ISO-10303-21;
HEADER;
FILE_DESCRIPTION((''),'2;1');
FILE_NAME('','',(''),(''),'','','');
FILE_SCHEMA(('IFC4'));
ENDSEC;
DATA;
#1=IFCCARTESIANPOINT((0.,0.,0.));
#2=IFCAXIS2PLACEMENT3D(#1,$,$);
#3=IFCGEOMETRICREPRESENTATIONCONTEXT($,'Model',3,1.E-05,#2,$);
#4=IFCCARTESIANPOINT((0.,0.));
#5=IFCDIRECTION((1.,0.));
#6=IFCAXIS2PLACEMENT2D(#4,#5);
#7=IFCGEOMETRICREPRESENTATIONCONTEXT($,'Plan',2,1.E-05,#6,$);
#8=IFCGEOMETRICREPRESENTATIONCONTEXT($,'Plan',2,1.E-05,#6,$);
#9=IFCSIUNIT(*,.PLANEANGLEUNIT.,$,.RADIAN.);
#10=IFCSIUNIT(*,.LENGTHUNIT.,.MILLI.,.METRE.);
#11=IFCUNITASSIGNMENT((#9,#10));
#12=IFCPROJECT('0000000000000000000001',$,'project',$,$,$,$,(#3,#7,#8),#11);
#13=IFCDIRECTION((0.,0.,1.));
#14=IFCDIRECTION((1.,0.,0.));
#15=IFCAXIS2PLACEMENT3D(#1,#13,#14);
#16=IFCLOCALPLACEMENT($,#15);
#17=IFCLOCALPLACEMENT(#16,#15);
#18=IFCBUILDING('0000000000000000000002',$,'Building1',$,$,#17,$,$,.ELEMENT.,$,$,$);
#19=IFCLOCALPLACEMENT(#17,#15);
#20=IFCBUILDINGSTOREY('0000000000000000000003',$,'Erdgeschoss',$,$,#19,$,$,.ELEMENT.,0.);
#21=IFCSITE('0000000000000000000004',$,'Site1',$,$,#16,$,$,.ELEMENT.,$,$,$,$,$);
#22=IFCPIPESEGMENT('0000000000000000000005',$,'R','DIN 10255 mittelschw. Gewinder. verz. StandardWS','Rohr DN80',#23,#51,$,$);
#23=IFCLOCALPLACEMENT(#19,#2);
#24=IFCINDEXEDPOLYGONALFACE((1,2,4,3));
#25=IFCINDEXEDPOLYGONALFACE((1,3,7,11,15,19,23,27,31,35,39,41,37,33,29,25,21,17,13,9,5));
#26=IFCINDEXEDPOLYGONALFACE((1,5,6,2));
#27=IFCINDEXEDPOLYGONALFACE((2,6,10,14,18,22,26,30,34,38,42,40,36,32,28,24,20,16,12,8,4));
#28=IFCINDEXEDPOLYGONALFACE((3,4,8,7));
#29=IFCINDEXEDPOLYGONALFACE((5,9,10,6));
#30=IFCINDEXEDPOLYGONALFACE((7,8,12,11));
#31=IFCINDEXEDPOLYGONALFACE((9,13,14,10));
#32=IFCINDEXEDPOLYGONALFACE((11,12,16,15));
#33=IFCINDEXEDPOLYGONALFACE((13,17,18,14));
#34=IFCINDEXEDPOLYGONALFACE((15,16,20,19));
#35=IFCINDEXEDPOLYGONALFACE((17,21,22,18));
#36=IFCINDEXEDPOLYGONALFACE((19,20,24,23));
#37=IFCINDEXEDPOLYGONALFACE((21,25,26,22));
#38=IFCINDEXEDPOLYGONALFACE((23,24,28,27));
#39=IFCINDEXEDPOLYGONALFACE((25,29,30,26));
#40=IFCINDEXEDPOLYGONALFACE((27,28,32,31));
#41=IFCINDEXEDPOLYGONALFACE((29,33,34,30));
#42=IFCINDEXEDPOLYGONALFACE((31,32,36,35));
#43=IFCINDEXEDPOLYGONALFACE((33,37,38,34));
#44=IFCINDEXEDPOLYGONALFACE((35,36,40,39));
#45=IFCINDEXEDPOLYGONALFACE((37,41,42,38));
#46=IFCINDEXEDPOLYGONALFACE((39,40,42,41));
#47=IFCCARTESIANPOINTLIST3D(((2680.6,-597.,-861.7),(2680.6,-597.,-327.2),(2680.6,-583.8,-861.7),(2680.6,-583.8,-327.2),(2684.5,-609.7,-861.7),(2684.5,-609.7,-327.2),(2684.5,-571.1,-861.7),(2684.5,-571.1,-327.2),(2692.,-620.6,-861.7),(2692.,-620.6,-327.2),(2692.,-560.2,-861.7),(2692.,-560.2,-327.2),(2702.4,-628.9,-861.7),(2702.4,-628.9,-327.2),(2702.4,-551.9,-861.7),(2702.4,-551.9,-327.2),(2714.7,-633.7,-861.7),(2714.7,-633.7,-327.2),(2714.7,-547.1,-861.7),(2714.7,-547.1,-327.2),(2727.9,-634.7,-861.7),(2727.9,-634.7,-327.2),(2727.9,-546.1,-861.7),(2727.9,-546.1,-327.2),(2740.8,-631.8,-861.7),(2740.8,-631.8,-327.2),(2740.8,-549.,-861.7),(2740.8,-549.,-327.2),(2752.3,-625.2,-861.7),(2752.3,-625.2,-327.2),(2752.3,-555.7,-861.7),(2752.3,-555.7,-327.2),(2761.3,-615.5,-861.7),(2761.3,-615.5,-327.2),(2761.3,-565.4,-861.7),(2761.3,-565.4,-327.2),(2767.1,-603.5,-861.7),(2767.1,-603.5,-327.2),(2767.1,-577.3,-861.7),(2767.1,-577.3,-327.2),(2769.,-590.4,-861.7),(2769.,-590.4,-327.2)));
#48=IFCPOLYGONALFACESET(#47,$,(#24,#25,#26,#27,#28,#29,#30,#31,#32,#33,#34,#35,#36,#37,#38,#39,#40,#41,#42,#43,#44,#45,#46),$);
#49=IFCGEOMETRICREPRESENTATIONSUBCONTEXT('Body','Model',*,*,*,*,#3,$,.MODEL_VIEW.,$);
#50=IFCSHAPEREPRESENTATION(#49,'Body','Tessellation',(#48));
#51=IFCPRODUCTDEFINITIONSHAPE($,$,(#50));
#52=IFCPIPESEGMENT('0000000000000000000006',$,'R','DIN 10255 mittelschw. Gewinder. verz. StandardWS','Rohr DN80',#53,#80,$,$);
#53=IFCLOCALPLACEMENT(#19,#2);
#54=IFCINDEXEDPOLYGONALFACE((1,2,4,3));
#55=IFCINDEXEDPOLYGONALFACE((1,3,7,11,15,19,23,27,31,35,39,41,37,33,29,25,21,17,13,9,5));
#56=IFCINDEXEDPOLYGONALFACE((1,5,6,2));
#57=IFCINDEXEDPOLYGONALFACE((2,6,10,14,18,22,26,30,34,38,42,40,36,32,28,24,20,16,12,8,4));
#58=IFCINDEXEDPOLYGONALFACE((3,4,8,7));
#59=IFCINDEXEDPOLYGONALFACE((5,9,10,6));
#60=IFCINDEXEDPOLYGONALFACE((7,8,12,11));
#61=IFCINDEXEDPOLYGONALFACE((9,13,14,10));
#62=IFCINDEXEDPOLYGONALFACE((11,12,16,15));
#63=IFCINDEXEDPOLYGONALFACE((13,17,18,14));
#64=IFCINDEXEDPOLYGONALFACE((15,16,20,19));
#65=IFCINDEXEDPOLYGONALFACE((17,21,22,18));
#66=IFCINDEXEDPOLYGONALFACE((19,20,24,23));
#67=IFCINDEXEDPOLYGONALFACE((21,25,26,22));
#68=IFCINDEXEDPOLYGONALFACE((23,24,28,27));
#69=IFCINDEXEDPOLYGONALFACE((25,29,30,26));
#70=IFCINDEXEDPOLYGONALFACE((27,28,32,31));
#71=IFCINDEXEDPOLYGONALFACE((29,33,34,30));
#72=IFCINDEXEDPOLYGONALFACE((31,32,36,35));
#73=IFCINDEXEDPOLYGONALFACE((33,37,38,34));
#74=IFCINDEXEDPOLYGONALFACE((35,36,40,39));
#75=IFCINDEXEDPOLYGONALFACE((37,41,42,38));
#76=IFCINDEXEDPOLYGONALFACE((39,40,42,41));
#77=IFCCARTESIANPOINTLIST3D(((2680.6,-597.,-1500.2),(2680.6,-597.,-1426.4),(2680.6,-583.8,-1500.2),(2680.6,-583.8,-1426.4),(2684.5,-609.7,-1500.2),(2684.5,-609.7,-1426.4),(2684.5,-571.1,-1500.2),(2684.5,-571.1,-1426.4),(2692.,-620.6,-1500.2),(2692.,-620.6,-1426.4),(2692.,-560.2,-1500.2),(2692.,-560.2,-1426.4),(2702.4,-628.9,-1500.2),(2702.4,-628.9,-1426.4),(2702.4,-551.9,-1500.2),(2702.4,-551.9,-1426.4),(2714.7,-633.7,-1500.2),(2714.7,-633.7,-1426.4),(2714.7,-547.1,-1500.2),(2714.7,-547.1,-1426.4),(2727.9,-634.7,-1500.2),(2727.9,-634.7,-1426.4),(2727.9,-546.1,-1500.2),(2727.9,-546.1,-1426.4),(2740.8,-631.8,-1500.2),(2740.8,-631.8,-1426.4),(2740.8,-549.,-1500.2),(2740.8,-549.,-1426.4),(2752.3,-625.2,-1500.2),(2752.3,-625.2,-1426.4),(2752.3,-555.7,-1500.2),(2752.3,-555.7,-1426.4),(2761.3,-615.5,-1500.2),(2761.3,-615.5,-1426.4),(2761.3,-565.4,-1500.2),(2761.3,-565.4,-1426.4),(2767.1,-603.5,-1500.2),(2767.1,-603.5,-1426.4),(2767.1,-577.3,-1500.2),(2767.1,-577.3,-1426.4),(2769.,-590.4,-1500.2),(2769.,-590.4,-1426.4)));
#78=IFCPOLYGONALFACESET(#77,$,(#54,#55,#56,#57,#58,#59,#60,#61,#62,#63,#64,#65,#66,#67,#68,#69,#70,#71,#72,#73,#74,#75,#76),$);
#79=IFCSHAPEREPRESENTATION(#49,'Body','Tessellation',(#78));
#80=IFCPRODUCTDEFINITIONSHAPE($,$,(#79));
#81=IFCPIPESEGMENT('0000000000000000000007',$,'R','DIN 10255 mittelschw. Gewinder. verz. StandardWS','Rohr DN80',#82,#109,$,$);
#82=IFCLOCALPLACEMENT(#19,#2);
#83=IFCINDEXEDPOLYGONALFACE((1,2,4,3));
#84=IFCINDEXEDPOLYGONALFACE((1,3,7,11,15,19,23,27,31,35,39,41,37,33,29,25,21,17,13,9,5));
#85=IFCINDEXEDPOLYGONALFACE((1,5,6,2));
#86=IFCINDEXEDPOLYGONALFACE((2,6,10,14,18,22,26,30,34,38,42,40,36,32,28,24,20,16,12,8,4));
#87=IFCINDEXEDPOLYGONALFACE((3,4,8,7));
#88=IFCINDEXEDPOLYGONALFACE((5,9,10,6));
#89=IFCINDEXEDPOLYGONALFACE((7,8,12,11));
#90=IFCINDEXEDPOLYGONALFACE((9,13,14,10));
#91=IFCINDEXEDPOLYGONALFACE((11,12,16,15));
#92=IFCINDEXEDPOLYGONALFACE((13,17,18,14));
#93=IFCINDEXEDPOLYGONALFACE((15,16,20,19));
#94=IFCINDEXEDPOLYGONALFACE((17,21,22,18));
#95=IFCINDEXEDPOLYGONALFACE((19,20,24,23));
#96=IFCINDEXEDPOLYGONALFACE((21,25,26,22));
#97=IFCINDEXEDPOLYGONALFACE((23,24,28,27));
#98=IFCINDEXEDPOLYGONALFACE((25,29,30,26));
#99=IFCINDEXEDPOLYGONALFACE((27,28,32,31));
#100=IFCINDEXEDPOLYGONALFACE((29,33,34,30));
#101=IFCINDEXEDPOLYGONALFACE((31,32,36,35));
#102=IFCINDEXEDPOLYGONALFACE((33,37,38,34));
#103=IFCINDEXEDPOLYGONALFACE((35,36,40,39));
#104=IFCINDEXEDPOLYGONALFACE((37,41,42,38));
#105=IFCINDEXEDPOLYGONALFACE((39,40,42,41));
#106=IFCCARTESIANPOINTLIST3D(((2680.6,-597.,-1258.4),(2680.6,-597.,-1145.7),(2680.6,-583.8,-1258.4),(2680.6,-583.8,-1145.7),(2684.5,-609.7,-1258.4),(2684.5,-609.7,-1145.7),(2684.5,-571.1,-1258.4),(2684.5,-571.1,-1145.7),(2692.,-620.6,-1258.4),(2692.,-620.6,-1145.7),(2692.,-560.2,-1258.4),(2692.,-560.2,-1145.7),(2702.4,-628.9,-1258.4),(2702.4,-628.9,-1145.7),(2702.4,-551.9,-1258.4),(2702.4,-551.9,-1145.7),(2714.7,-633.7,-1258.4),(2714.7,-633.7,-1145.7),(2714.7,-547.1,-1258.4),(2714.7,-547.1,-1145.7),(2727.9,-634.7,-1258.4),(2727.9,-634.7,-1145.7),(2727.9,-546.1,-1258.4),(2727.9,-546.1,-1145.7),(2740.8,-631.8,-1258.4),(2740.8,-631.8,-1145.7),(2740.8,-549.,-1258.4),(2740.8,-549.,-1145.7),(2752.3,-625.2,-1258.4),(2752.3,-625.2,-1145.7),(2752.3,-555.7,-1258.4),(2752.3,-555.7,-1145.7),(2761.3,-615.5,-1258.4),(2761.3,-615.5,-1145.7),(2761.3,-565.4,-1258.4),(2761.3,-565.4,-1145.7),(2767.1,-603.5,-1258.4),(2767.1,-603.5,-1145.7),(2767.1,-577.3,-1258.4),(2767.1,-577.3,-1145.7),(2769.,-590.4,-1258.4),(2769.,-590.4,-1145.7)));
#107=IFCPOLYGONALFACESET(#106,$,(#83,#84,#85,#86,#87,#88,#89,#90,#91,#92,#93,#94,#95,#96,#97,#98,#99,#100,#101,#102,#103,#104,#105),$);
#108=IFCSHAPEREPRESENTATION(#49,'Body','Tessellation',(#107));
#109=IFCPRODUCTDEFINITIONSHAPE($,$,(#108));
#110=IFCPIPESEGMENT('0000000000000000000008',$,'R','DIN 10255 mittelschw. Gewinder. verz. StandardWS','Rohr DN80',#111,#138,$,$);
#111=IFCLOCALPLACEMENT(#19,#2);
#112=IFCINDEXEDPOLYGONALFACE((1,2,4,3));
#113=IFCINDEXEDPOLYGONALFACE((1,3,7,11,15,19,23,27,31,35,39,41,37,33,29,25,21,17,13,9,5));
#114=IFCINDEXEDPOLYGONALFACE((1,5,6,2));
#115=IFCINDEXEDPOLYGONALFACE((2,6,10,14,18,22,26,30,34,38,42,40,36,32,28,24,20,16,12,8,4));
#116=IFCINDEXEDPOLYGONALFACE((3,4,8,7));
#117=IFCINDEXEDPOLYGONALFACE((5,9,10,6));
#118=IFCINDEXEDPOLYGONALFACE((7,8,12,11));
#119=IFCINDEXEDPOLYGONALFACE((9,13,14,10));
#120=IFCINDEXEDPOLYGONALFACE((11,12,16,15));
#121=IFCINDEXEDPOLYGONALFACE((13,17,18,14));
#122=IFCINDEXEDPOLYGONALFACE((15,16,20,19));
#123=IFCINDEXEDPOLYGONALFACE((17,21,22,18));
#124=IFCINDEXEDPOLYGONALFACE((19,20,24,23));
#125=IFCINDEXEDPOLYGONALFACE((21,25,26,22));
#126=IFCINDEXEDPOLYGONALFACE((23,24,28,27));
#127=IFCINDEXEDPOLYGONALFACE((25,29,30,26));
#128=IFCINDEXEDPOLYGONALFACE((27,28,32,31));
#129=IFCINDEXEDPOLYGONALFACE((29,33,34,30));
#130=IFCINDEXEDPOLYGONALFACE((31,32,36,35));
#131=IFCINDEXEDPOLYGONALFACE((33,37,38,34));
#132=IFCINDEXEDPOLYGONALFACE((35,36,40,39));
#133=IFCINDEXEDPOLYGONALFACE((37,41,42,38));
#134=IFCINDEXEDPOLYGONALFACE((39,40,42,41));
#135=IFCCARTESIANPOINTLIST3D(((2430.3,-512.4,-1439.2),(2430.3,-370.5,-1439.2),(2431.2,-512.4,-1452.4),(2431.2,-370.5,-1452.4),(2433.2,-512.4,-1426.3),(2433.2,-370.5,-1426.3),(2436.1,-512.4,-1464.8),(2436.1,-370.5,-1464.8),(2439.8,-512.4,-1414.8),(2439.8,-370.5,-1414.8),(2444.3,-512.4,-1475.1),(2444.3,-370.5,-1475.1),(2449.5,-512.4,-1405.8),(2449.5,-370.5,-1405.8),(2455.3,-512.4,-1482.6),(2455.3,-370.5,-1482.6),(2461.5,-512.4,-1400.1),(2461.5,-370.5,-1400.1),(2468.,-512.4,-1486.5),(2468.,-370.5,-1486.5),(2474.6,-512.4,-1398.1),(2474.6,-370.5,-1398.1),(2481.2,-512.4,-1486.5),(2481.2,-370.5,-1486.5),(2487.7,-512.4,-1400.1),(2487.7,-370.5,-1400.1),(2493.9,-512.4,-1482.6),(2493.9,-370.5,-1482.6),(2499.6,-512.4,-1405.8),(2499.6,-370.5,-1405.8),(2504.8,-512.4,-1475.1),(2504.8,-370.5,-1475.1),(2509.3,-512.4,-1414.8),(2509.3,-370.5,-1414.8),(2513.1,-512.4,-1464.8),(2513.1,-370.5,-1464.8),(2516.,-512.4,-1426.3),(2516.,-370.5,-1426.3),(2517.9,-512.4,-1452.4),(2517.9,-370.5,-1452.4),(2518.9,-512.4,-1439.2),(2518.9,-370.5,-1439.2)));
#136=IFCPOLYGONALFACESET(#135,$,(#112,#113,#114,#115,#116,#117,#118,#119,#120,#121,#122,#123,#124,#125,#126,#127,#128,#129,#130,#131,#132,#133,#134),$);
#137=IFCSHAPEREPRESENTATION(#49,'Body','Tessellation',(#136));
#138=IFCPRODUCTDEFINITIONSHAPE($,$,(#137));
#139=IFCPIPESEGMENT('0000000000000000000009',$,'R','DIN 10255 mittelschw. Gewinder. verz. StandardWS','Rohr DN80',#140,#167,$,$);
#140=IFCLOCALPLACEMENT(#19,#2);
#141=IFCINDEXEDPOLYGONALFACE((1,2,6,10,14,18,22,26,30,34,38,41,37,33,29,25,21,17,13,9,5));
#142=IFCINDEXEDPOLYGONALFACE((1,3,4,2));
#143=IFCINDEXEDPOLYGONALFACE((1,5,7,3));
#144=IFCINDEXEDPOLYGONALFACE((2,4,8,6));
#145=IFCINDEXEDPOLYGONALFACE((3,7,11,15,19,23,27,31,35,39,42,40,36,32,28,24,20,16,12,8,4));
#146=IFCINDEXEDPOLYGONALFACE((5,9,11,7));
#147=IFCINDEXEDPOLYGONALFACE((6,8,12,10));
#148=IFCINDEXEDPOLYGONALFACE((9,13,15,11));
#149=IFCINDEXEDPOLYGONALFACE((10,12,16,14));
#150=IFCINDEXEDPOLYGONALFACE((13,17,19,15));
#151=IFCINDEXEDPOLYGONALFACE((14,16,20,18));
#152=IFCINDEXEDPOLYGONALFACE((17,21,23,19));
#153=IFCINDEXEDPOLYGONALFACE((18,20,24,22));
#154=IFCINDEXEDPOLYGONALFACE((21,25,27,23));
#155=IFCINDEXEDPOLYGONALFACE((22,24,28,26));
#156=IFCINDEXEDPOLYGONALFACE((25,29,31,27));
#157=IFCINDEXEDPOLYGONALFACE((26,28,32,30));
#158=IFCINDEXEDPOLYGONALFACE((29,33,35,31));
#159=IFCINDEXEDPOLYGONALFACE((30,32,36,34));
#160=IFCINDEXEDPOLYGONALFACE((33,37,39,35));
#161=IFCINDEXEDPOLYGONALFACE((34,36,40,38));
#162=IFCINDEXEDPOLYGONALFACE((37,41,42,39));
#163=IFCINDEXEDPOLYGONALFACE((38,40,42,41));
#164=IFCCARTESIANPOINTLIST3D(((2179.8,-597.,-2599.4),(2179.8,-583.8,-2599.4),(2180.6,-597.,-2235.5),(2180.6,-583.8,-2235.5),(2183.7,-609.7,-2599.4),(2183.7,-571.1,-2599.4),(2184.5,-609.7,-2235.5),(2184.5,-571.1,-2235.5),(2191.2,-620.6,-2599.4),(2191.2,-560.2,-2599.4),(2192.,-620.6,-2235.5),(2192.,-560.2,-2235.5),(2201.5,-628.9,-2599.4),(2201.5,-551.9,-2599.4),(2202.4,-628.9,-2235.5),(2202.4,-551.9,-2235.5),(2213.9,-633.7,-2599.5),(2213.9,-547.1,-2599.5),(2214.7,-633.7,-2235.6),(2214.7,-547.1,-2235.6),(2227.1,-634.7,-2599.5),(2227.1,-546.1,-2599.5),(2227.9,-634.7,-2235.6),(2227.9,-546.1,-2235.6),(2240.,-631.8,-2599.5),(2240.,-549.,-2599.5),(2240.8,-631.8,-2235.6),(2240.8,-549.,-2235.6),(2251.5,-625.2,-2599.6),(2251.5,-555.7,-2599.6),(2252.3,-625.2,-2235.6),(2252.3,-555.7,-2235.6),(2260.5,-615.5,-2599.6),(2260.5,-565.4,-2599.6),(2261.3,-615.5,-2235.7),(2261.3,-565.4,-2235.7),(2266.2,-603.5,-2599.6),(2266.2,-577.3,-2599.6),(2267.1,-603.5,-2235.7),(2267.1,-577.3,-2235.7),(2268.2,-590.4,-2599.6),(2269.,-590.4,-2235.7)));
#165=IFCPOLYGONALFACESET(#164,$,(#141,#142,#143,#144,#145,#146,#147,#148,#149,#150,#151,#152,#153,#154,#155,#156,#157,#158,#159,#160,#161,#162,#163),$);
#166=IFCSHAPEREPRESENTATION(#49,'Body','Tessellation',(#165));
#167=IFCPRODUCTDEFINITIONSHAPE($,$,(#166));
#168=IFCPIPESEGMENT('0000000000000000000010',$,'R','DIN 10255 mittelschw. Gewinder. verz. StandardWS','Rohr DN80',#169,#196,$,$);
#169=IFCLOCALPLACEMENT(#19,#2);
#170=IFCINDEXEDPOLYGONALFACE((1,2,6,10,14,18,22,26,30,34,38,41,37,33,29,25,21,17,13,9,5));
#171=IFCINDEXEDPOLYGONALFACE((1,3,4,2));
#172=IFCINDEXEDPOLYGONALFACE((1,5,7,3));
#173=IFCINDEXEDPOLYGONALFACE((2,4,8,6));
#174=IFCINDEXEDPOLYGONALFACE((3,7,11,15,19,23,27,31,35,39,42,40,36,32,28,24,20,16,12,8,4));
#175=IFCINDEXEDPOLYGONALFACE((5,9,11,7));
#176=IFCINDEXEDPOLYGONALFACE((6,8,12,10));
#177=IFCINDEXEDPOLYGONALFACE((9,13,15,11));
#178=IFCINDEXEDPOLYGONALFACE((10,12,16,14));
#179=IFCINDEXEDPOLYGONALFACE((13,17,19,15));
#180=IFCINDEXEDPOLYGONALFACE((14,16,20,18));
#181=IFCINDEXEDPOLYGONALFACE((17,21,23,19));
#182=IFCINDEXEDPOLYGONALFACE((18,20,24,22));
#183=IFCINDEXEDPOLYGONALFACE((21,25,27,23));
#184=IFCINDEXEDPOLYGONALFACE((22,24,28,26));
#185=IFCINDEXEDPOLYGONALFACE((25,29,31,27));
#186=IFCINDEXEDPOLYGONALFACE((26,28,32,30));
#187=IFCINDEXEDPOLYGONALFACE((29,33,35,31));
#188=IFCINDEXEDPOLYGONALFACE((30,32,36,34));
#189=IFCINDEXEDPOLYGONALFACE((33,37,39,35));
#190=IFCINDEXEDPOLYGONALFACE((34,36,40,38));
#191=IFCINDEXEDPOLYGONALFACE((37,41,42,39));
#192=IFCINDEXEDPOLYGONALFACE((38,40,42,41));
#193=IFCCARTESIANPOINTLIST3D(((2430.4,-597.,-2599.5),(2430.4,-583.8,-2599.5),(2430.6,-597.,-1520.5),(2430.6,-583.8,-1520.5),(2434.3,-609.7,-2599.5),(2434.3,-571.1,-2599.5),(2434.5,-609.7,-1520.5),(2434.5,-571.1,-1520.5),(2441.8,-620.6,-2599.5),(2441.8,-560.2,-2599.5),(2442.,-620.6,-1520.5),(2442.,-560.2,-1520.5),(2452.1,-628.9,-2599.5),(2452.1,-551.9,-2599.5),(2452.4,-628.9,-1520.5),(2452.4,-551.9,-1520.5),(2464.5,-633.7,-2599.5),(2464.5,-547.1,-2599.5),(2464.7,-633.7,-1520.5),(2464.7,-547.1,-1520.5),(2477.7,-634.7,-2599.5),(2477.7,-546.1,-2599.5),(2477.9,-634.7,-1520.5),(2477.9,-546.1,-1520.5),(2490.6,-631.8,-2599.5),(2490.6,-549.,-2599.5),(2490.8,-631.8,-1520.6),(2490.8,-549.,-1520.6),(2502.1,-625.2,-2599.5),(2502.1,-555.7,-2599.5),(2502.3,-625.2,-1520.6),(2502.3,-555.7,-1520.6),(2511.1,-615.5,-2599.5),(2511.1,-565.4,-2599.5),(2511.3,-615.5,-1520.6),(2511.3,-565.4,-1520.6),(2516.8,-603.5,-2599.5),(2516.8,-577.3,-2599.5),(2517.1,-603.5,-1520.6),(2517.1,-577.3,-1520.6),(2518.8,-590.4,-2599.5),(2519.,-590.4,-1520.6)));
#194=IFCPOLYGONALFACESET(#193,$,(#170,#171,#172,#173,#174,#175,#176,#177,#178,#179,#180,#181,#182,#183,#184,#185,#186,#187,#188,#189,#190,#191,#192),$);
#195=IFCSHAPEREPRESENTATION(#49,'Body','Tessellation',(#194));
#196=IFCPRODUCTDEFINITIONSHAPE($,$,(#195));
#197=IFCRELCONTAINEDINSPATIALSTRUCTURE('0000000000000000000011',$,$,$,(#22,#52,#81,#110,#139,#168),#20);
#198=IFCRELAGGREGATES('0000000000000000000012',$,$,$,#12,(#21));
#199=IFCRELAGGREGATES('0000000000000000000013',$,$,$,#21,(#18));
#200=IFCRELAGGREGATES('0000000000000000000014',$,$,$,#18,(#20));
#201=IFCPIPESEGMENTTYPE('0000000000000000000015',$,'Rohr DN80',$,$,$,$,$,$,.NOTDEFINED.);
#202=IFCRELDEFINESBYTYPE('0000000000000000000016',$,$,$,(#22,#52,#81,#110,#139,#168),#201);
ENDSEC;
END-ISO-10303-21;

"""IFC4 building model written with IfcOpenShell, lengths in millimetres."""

from ifc_helpers import new_model, si_unit, frame, origin, origin_with_axes, origin_2d_with_axis, place, context, subcontext, project, spatial, circle, extrude, type_object, element, save


model = new_model("IFC4")

# Units and contexts
model_context = context("Model", 3, precision=1e-05, world=origin())
plan_context_1 = context("Plan", 2, precision=1e-05, world=origin_2d_with_axis())
plan_context_2 = context("Plan", 2, precision=1e-05, world=origin_2d_with_axis())
body_context = subcontext(model_context, "Body", "Model", "MODEL_VIEW")
ifc_project = project(units=[si_unit("PLANEANGLEUNIT", "RADIAN"), si_unit("LENGTHUNIT", "METRE", prefix="MILLI")], contexts=[model_context, plan_context_1, plan_context_2])

# Site, building, storey
site_placement = place(None, origin_with_axes())
site = spatial("IfcSite", under=ifc_project, at=site_placement, Name="Site1", CompositionType="ELEMENT")
building_placement = place(site_placement, origin_with_axes())
building = spatial("IfcBuilding", under=site, at=building_placement, Name="Building1", CompositionType="ELEMENT")
storey_placement = place(building_placement, origin_with_axes())
storey = spatial("IfcBuildingStorey", under=building, at=storey_placement, Name="Erdgeschoss", CompositionType="ELEMENT", Elevation=0.0)

# Pipe segments
pipe_segment_type_1 = type_object("IfcPipeSegmentType", Name="Rohr DN80", PredefinedType="NOTDEFINED")
pipe_segment_1_placement = place(storey_placement, frame((2724.6, -590.6, -594.5), z_axis=(0.0, 0.0, 1.0), x_axis=(1.0, 0.0, 0.0)))
element("IfcPipeSegment", 1, at=pipe_segment_1_placement, inside=storey, type_object=pipe_segment_type_1, Name="R", Description="DIN 10255 mittelschw. Gewinder. verz. StandardWS", ObjectType="Rohr DN80", context=body_context, shape_type="SolidModel", body=[
    extrude(circle(Radius=44.5, at=origin_2d_with_axis()), frame((0.0, 0.1, -267.2), z_axis=(0.0, 0.0, 1.0), x_axis=(1.0, 0.0, 0.0)), (0.0, 0.0, 1.0), 534.5),
])
pipe_segment_2_placement = place(storey_placement, frame((2724.6, -590.6, -1463.3), z_axis=(0.0, 0.0, 1.0), x_axis=(1.0, 0.0, 0.0)))
element("IfcPipeSegment", 2, at=pipe_segment_2_placement, inside=storey, type_object=pipe_segment_type_1, Name="R", Description="DIN 10255 mittelschw. Gewinder. verz. StandardWS", ObjectType="Rohr DN80", context=body_context, shape_type="SolidModel", body=[
    extrude(circle(Radius=44.5, at=origin_2d_with_axis()), frame((0.0, 0.1, -36.9), z_axis=(0.0, 0.0, 1.0), x_axis=(1.0, 0.0, 0.0)), (0.0, 0.0, 1.0), 73.8),
])
pipe_segment_3_placement = place(storey_placement, frame((2724.6, -590.6, -1202.1), z_axis=(0.0, 0.0, 1.0), x_axis=(1.0, 0.0, 0.0)))
element("IfcPipeSegment", 3, at=pipe_segment_3_placement, inside=storey, type_object=pipe_segment_type_1, Name="R", Description="DIN 10255 mittelschw. Gewinder. verz. StandardWS", ObjectType="Rohr DN80", context=body_context, shape_type="SolidModel", body=[
    extrude(circle(Radius=44.5, at=origin_2d_with_axis()), frame((0.0, 0.1, -56.3), z_axis=(0.0, 0.0, 1.0), x_axis=(1.0, 0.0, 0.0)), (0.0, 0.0, 1.0), 112.7),
])
pipe_segment_4_placement = place(storey_placement, frame((2474.4, -441.5, -1442.5), z_axis=(0.0, 0.0, 1.0), x_axis=(1.0, 0.0, 0.0)))
element("IfcPipeSegment", 4, at=pipe_segment_4_placement, inside=storey, type_object=pipe_segment_type_1, Name="R", Description="DIN 10255 mittelschw. Gewinder. verz. StandardWS", ObjectType="Rohr DN80", context=body_context, shape_type="SolidModel", body=[
    extrude(circle(Radius=44.5, at=origin_2d_with_axis()), frame((0.2, -70.9, 0.0), z_axis=(0.0, 1.0, 0.0), x_axis=(0.0, 0.0, 1.0)), (0.0, 0.0, 1.0), 141.9),
])
pipe_segment_5_placement = place(storey_placement, frame((2224.2, -590.6, -2417.5), z_axis=(0.0, 0.0, 1.0), x_axis=(1.0, 0.0, 0.0)))
element("IfcPipeSegment", 5, at=pipe_segment_5_placement, inside=storey, type_object=pipe_segment_type_1, Name="R", Description="DIN 10255 mittelschw. Gewinder. verz. StandardWS", ObjectType="Rohr DN80", context=body_context, shape_type="SolidModel", body=[
    extrude(circle(Radius=44.5, at=origin_2d_with_axis()), frame((-0.4, 0.1, -182.0), z_axis=(0.002292, 0.0, 0.999997), x_axis=(1.0, 0.0, 0.0)), (0.0, 0.0, 1.0), 363.9),
])
pipe_segment_6_placement = place(storey_placement, frame((2474.5, -590.6, -2060.0), z_axis=(0.0, 0.0, 1.0), x_axis=(1.0, 0.0, 0.0)))
element("IfcPipeSegment", 6, at=pipe_segment_6_placement, inside=storey, type_object=pipe_segment_type_1, Name="R", Description="DIN 10255 mittelschw. Gewinder. verz. StandardWS", ObjectType="Rohr DN80", context=body_context, shape_type="SolidModel", body=[
    extrude(circle(Radius=44.5, at=origin_2d_with_axis()), frame((-0.1, 0.2, -539.5), z_axis=(0.000217, 0.0, 1.0), x_axis=(1.0, 0.0, 0.0)), (0.0, 0.0, 1.0), 1079.0),
])

save(model, "model.ifc")
